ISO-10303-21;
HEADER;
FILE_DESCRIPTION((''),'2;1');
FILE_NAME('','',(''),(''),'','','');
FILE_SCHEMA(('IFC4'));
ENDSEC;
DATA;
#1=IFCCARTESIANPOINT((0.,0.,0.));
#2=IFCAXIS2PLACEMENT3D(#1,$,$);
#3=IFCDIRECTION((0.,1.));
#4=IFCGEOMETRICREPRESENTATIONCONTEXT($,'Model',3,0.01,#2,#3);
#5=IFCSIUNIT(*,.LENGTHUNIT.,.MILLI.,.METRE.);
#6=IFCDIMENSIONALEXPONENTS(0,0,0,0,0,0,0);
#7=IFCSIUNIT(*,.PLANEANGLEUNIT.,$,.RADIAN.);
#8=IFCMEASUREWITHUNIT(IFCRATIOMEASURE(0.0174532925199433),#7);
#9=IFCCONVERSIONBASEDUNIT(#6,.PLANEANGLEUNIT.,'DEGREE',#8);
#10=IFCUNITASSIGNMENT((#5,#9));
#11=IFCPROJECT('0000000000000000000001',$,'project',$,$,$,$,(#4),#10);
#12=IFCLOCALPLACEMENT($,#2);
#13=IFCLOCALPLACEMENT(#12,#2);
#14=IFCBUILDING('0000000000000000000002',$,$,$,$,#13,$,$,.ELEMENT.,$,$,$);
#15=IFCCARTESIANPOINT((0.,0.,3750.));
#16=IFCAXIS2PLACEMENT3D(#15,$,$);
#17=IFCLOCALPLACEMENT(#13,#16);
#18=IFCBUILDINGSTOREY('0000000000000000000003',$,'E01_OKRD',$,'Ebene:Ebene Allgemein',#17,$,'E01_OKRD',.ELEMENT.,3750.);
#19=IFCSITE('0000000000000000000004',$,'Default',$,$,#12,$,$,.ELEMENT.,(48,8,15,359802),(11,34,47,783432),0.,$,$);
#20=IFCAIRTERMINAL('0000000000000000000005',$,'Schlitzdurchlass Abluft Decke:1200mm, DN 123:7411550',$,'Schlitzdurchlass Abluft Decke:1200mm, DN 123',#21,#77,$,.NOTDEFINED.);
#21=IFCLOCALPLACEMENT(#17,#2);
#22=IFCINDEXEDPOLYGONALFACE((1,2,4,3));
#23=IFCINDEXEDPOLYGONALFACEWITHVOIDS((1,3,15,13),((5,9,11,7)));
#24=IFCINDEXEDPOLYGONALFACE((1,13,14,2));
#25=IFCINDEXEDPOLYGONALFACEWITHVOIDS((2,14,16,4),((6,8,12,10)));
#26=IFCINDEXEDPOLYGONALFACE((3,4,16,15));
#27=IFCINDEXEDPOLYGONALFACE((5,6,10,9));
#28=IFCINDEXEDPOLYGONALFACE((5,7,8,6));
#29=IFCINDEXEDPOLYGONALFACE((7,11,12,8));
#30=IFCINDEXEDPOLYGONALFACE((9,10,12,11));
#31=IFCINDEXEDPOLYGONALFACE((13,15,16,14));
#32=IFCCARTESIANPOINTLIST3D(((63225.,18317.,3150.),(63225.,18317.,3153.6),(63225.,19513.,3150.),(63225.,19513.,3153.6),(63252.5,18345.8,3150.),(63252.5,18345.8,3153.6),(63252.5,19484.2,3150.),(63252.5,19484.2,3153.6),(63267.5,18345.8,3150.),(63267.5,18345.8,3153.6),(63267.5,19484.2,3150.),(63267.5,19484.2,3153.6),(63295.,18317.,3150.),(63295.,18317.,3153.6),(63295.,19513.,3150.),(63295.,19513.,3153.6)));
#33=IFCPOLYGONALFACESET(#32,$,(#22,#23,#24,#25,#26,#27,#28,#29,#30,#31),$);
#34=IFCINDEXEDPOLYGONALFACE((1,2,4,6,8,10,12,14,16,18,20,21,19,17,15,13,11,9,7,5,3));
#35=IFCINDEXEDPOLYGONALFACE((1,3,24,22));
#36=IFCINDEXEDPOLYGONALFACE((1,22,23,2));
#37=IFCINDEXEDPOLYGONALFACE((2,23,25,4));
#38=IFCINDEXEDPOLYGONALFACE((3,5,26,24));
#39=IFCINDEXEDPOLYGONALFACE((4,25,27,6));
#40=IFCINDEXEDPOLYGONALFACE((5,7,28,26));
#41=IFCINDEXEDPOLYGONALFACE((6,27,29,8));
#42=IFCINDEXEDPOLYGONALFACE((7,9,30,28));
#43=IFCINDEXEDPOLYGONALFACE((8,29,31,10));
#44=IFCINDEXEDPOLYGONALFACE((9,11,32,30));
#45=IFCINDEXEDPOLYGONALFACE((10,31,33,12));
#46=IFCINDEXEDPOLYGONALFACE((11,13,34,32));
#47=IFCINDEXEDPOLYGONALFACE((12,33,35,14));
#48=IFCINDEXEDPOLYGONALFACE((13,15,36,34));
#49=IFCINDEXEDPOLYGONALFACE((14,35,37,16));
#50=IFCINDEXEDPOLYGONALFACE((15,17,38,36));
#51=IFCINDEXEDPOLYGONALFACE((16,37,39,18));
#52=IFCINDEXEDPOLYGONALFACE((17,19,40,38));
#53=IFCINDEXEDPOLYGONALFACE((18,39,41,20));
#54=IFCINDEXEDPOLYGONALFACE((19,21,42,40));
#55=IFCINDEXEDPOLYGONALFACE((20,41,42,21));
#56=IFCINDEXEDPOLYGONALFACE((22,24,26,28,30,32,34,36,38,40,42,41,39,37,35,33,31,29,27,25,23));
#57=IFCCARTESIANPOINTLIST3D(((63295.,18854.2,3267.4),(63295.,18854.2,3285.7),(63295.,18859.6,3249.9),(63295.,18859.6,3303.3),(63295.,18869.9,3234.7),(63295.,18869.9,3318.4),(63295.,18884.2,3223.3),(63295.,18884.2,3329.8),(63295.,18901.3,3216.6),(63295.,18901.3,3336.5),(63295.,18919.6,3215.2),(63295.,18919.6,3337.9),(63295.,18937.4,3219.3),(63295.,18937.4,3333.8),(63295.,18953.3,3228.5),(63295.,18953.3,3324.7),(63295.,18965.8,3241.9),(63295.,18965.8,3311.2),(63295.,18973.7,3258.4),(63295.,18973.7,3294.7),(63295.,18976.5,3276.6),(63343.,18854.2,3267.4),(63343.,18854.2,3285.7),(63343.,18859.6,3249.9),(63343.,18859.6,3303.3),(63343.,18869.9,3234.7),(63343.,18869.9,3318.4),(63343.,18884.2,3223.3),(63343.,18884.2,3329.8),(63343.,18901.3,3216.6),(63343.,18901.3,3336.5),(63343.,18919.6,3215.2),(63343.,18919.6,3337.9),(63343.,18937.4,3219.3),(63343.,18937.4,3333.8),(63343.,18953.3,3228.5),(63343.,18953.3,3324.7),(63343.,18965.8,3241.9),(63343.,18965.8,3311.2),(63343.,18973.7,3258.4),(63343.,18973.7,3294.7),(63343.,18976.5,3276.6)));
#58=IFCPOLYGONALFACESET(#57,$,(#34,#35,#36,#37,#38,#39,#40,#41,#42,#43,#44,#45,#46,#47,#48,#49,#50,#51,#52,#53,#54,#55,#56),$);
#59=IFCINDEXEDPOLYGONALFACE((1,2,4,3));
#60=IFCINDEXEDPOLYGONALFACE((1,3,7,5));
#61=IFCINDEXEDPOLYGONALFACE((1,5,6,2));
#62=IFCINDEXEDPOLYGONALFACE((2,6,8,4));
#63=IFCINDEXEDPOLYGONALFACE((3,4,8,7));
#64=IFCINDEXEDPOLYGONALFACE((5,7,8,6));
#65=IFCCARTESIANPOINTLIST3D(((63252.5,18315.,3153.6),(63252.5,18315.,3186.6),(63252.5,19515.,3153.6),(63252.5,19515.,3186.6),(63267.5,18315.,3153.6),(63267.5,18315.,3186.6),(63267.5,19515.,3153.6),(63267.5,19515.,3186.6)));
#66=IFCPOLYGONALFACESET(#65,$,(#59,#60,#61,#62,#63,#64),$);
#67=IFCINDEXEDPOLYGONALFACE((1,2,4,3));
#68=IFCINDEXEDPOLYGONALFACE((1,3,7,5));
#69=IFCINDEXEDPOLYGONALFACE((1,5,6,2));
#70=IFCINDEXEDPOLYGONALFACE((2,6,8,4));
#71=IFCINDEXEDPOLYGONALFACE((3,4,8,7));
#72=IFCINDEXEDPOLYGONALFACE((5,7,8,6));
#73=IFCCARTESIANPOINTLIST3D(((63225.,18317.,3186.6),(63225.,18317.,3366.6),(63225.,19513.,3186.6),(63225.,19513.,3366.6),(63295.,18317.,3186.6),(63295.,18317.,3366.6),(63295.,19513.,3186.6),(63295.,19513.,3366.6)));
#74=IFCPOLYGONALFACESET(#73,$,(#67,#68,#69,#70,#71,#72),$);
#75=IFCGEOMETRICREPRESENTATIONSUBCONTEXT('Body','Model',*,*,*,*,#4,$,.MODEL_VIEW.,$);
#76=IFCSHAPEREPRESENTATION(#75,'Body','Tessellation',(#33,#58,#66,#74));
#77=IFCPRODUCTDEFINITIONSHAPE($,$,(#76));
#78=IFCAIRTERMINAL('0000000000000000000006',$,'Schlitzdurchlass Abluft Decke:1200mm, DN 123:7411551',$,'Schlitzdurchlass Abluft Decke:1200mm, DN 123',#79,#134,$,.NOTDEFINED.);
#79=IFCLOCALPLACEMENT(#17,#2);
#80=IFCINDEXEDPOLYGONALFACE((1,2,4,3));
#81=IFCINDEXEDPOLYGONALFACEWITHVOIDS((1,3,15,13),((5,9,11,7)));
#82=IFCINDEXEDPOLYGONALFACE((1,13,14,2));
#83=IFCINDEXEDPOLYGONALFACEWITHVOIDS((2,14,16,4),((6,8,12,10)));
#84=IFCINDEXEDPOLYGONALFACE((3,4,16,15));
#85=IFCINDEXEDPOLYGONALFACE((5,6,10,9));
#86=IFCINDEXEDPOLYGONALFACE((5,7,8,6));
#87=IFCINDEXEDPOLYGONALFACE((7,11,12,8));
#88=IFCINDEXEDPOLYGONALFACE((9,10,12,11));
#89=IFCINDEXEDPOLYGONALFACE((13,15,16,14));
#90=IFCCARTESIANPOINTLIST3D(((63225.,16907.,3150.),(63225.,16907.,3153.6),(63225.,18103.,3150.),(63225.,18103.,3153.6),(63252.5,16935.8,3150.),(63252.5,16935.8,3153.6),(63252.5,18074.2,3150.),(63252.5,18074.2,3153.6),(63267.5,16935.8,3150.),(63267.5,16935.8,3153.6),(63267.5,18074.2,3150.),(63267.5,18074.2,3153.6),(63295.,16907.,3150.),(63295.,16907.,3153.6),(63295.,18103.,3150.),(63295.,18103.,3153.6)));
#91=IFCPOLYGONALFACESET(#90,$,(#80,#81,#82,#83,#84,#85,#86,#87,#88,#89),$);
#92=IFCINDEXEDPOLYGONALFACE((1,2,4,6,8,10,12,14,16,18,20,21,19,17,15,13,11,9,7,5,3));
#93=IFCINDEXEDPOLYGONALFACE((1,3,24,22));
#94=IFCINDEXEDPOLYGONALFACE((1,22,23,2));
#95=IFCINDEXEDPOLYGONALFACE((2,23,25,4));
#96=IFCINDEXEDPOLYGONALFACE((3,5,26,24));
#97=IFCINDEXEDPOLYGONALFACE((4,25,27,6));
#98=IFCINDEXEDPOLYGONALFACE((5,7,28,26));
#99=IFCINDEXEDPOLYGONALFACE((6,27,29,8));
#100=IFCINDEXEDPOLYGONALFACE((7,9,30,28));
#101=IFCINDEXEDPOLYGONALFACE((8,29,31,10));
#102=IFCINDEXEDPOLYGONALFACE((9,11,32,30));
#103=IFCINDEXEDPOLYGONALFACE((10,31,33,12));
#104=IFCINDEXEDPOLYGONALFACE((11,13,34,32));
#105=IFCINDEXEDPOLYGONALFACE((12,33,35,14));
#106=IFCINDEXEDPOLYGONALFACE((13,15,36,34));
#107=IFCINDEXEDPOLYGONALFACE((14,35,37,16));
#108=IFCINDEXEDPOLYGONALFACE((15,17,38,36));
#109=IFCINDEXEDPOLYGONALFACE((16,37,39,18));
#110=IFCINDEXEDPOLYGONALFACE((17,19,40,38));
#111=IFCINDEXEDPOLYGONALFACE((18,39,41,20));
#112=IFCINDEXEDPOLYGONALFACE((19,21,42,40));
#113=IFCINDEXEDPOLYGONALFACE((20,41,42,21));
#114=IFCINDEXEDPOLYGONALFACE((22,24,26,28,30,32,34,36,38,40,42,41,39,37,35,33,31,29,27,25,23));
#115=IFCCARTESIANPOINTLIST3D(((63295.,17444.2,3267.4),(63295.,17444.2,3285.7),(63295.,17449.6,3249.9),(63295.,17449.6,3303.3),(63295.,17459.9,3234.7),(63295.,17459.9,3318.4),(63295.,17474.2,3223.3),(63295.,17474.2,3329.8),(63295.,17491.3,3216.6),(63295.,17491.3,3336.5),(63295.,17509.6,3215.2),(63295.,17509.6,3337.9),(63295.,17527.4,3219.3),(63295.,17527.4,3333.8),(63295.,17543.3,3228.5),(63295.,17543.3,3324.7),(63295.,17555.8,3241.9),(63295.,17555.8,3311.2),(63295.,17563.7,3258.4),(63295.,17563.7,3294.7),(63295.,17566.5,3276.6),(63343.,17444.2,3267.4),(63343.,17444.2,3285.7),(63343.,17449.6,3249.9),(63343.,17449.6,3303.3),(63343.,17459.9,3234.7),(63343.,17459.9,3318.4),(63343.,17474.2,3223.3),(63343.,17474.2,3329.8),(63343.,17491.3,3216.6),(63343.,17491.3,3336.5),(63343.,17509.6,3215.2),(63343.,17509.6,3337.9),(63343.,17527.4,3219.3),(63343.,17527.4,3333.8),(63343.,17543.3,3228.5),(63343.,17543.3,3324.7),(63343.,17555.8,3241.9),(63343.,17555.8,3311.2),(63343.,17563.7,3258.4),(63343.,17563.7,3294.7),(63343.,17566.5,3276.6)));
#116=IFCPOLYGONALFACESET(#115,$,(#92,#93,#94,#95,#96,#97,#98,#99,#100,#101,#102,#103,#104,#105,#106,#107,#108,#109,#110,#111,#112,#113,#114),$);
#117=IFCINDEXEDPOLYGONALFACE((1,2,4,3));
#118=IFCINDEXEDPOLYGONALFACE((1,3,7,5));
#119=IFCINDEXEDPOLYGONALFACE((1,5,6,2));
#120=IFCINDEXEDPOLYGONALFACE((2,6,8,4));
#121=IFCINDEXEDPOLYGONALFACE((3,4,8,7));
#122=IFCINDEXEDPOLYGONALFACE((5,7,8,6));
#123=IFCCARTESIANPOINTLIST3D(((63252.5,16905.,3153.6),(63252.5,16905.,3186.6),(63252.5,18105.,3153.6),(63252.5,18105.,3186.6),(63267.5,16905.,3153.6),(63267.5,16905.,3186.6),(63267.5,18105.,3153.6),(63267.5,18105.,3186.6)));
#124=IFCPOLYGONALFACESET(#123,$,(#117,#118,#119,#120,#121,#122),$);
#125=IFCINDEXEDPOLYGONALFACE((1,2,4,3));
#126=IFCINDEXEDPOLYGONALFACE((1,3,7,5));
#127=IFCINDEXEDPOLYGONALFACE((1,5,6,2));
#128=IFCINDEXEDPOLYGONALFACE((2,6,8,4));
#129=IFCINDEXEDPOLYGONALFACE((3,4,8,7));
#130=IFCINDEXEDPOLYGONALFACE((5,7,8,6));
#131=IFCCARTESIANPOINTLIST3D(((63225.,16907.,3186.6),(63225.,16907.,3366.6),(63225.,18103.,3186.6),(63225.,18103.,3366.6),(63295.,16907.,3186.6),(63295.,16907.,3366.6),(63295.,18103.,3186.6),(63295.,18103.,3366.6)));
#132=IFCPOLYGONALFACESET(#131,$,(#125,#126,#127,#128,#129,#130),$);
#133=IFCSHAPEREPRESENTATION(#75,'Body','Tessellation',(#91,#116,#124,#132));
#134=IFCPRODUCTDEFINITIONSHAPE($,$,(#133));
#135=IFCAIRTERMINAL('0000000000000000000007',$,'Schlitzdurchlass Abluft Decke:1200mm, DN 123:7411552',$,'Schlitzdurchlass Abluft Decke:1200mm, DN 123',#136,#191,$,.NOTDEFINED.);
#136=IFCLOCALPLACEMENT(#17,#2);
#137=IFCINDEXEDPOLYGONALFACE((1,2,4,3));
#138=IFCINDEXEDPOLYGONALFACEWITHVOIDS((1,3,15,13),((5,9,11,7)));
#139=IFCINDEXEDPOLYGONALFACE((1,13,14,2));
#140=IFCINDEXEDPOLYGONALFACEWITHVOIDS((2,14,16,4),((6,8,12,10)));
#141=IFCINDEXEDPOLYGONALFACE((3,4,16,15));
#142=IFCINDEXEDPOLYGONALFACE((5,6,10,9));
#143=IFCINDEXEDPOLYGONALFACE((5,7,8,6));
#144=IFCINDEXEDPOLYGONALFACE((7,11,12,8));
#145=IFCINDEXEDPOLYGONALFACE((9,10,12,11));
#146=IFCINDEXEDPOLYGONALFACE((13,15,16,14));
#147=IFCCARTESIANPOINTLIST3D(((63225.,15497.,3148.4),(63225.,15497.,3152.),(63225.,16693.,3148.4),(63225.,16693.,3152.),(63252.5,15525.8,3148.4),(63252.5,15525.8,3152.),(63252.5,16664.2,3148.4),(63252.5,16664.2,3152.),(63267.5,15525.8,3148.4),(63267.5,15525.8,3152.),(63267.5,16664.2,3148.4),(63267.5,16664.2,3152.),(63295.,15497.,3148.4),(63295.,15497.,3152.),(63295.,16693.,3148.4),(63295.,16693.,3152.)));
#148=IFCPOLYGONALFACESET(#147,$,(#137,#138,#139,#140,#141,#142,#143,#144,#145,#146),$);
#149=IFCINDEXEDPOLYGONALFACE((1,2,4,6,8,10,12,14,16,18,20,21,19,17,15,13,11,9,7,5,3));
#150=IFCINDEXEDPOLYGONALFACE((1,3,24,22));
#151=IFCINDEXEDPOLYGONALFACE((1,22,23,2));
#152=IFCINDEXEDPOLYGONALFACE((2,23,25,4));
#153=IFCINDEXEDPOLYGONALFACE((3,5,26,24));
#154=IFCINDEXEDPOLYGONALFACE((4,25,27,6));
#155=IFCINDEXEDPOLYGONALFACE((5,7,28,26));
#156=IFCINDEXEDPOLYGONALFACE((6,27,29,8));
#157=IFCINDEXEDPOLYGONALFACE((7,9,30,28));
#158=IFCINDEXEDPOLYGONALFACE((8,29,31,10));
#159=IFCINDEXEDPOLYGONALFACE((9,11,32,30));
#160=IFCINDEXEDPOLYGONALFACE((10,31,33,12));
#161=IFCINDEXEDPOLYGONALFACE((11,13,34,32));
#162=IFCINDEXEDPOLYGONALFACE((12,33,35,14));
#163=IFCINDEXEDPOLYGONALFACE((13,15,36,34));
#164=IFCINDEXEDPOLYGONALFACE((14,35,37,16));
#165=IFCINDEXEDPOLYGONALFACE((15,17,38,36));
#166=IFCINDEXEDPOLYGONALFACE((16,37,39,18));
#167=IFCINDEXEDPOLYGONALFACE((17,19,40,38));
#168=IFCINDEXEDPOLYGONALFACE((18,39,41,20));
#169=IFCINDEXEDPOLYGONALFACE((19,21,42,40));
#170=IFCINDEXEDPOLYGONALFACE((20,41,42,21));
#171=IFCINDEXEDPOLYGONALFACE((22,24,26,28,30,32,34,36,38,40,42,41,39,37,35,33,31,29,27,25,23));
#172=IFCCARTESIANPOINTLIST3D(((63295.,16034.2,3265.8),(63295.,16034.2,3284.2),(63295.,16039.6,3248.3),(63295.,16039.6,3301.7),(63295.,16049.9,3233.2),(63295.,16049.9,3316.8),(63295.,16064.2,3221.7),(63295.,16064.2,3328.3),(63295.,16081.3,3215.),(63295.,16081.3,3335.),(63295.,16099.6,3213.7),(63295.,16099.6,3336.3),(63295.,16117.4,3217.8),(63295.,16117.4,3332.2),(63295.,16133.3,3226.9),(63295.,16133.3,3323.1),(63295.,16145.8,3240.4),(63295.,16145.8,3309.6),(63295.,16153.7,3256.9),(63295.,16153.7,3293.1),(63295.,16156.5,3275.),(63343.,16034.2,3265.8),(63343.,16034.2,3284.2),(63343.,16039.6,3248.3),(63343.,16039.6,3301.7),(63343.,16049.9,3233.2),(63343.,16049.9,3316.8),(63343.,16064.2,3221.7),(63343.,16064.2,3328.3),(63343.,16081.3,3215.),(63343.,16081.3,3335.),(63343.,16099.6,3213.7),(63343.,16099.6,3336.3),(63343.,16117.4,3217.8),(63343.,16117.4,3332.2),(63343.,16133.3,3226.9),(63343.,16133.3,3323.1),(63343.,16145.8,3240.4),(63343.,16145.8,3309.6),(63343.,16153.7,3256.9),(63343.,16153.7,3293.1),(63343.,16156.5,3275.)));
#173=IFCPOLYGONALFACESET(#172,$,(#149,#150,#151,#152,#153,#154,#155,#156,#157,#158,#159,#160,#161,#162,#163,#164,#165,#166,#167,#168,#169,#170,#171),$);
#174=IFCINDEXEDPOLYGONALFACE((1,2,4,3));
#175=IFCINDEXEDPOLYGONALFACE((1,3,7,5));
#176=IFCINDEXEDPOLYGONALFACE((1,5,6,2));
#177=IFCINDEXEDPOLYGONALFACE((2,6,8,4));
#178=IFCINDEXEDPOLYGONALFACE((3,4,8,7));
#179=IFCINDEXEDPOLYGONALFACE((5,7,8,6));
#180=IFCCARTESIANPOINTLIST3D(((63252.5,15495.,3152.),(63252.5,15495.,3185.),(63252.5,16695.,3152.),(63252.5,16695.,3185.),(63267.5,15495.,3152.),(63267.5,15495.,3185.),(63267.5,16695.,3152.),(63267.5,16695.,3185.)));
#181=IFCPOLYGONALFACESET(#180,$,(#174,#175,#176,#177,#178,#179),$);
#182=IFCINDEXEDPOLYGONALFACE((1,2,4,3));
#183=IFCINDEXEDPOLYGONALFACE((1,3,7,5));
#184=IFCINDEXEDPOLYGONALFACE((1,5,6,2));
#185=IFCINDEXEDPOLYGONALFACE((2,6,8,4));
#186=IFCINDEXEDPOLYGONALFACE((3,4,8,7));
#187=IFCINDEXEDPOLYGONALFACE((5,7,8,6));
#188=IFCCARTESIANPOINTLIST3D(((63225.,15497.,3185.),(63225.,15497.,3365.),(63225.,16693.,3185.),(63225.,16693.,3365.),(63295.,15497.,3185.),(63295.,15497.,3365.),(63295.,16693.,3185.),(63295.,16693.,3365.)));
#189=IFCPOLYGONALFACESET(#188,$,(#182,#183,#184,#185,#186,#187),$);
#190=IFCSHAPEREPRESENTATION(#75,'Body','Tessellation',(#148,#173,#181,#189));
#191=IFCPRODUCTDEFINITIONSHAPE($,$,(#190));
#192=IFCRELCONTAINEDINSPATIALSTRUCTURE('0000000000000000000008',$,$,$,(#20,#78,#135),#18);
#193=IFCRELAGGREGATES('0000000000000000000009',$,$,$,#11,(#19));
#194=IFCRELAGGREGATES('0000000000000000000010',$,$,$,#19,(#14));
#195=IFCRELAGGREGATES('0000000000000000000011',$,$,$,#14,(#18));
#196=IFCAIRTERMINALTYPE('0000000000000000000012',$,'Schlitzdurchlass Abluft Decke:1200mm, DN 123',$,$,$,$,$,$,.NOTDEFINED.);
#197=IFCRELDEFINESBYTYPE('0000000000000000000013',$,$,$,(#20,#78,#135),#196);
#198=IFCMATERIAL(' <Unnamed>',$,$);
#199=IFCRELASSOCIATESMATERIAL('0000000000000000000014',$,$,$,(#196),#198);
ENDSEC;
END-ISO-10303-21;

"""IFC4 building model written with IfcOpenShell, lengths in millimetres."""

from ifc_helpers import new_model, entity, si_unit, converted_unit, direction, frame, frame_2d, origin, origin_2d_with_axis, place, context, subcontext, project, spatial, polyline, rectangle, circle, outline, extrude, source, transform, mapped, material, type_object, type_shapes, element, save


model = new_model("IFC4")

# Units and contexts
model_context = context("Model", 3, precision=0.01, world=origin(), true_north=direction((0.0, 1.0)))
body_context = subcontext(model_context, "Body", "Model", "MODEL_VIEW")
ifc_project = project(units=[si_unit("LENGTHUNIT", "METRE", prefix="MILLI"), converted_unit("PLANEANGLEUNIT", "DEGREE", entity("IfcRatioMeasure", 0.0174532925199433), si_unit("PLANEANGLEUNIT", "RADIAN"), dimensions=[0, 0, 0, 0, 0, 0, 0])], contexts=[model_context])

# Site, building, storey
site_placement = place(None, origin())
site = spatial("IfcSite", under=ifc_project, at=site_placement, Name="Default", CompositionType="ELEMENT", RefLatitude=(48, 8, 15, 359802), RefLongitude=(11, 34, 47, 783432), RefElevation=0.0)
building_placement = place(site_placement, origin())
building = spatial("IfcBuilding", under=site, at=building_placement, CompositionType="ELEMENT")
storey_placement = place(building_placement, frame((0.0, 0.0, 3750.0)))
storey = spatial("IfcBuildingStorey", under=building, at=storey_placement, Name="E01_OKRD", ObjectType="Ebene:Ebene Allgemein", LongName="E01_OKRD", CompositionType="ELEMENT", Elevation=3750.0)

# Shared definitions
ifc_material_1 = material(Name=" <Unnamed>")

# Air terminals
air_terminal_type_1 = type_object("IfcAirTerminalType", Name="Schlitzdurchlass Abluft Decke:1200mm, DN 123", PredefinedType="NOTDEFINED", material=ifc_material_1)
shared_shape_1 = source(origin(), body_context, "Body", "SweptSolid", [
    extrude(outline(polyline([(-598.0, -35.0), (598.0, -35.0), (598.0, 35.0), (-598.0, 35.0), (-598.0, -35.0)]), holes=[polyline([(-569.2, -7.5), (-569.2, 7.5), (569.2, 7.5), (569.2, -7.5), (-569.2, -7.5)])]), frame((0.0, 0.0, 0.0), z_axis=(0.0, 0.0, 1.0), x_axis=(-1.0, 0.0, 0.0)), (0.0, 0.0, 1.0), 3.6),
    extrude(circle(Radius=61.5, at=frame_2d((0.0, 0.0), x_axis=(1.0, 0.0))), frame((0.0, 35.0, 126.6), z_axis=(0.0, 1.0, 0.0), x_axis=(-1.0, 0.0, 0.0)), (0.0, 0.0, 1.0), 48.0),
    extrude(rectangle(XDim=1200.0, YDim=15.0, at=origin_2d_with_axis()), frame((0.0, 0.0, 3.6), z_axis=(0.0, 0.0, 1.0), x_axis=(-1.0, 0.0, 0.0)), (0.0, 0.0, 1.0), 33.0),
    extrude(rectangle(XDim=1196.0, YDim=70.0, at=origin_2d_with_axis()), frame((0.0, 0.0, 36.6), z_axis=(0.0, 0.0, 1.0), x_axis=(-1.0, 0.0, 0.0)), (0.0, 0.0, 1.0), 180.0),
])
type_shapes(air_terminal_type_1, [shared_shape_1])
for number, where, z_axis, x_axis, name in (
    (1, (63260.0, 18915.0, 3150.0), (0.0, 0.0, 1.0), (0.0, -1.0, 0.0), "Schlitzdurchlass Abluft Decke:1200mm, DN 123:7411550"),
    (2, (63260.0, 17505.0, 3150.0), (0.0, 0.0, 1.0), (0.0, -1.0, 0.0), "Schlitzdurchlass Abluft Decke:1200mm, DN 123:7411551"),
    (3, (63260.0, 16095.0, 3148.4), (0.0, 0.0, 1.0), (0.0, -1.0, 0.0), "Schlitzdurchlass Abluft Decke:1200mm, DN 123:7411552"),
):
    element("IfcAirTerminal", number, at=place(storey_placement, frame(where, z_axis=z_axis, x_axis=x_axis)), inside=storey, type_object=air_terminal_type_1, Name=name, ObjectType="Schlitzdurchlass Abluft Decke:1200mm, DN 123", PredefinedType="NOTDEFINED", context=body_context, shape_type="MappedRepresentation", body=[
        mapped(shared_shape_1, transform((0.0, 0.0, 0.0), scale=1.0)),
    ])

save(model, "model.ifc")
